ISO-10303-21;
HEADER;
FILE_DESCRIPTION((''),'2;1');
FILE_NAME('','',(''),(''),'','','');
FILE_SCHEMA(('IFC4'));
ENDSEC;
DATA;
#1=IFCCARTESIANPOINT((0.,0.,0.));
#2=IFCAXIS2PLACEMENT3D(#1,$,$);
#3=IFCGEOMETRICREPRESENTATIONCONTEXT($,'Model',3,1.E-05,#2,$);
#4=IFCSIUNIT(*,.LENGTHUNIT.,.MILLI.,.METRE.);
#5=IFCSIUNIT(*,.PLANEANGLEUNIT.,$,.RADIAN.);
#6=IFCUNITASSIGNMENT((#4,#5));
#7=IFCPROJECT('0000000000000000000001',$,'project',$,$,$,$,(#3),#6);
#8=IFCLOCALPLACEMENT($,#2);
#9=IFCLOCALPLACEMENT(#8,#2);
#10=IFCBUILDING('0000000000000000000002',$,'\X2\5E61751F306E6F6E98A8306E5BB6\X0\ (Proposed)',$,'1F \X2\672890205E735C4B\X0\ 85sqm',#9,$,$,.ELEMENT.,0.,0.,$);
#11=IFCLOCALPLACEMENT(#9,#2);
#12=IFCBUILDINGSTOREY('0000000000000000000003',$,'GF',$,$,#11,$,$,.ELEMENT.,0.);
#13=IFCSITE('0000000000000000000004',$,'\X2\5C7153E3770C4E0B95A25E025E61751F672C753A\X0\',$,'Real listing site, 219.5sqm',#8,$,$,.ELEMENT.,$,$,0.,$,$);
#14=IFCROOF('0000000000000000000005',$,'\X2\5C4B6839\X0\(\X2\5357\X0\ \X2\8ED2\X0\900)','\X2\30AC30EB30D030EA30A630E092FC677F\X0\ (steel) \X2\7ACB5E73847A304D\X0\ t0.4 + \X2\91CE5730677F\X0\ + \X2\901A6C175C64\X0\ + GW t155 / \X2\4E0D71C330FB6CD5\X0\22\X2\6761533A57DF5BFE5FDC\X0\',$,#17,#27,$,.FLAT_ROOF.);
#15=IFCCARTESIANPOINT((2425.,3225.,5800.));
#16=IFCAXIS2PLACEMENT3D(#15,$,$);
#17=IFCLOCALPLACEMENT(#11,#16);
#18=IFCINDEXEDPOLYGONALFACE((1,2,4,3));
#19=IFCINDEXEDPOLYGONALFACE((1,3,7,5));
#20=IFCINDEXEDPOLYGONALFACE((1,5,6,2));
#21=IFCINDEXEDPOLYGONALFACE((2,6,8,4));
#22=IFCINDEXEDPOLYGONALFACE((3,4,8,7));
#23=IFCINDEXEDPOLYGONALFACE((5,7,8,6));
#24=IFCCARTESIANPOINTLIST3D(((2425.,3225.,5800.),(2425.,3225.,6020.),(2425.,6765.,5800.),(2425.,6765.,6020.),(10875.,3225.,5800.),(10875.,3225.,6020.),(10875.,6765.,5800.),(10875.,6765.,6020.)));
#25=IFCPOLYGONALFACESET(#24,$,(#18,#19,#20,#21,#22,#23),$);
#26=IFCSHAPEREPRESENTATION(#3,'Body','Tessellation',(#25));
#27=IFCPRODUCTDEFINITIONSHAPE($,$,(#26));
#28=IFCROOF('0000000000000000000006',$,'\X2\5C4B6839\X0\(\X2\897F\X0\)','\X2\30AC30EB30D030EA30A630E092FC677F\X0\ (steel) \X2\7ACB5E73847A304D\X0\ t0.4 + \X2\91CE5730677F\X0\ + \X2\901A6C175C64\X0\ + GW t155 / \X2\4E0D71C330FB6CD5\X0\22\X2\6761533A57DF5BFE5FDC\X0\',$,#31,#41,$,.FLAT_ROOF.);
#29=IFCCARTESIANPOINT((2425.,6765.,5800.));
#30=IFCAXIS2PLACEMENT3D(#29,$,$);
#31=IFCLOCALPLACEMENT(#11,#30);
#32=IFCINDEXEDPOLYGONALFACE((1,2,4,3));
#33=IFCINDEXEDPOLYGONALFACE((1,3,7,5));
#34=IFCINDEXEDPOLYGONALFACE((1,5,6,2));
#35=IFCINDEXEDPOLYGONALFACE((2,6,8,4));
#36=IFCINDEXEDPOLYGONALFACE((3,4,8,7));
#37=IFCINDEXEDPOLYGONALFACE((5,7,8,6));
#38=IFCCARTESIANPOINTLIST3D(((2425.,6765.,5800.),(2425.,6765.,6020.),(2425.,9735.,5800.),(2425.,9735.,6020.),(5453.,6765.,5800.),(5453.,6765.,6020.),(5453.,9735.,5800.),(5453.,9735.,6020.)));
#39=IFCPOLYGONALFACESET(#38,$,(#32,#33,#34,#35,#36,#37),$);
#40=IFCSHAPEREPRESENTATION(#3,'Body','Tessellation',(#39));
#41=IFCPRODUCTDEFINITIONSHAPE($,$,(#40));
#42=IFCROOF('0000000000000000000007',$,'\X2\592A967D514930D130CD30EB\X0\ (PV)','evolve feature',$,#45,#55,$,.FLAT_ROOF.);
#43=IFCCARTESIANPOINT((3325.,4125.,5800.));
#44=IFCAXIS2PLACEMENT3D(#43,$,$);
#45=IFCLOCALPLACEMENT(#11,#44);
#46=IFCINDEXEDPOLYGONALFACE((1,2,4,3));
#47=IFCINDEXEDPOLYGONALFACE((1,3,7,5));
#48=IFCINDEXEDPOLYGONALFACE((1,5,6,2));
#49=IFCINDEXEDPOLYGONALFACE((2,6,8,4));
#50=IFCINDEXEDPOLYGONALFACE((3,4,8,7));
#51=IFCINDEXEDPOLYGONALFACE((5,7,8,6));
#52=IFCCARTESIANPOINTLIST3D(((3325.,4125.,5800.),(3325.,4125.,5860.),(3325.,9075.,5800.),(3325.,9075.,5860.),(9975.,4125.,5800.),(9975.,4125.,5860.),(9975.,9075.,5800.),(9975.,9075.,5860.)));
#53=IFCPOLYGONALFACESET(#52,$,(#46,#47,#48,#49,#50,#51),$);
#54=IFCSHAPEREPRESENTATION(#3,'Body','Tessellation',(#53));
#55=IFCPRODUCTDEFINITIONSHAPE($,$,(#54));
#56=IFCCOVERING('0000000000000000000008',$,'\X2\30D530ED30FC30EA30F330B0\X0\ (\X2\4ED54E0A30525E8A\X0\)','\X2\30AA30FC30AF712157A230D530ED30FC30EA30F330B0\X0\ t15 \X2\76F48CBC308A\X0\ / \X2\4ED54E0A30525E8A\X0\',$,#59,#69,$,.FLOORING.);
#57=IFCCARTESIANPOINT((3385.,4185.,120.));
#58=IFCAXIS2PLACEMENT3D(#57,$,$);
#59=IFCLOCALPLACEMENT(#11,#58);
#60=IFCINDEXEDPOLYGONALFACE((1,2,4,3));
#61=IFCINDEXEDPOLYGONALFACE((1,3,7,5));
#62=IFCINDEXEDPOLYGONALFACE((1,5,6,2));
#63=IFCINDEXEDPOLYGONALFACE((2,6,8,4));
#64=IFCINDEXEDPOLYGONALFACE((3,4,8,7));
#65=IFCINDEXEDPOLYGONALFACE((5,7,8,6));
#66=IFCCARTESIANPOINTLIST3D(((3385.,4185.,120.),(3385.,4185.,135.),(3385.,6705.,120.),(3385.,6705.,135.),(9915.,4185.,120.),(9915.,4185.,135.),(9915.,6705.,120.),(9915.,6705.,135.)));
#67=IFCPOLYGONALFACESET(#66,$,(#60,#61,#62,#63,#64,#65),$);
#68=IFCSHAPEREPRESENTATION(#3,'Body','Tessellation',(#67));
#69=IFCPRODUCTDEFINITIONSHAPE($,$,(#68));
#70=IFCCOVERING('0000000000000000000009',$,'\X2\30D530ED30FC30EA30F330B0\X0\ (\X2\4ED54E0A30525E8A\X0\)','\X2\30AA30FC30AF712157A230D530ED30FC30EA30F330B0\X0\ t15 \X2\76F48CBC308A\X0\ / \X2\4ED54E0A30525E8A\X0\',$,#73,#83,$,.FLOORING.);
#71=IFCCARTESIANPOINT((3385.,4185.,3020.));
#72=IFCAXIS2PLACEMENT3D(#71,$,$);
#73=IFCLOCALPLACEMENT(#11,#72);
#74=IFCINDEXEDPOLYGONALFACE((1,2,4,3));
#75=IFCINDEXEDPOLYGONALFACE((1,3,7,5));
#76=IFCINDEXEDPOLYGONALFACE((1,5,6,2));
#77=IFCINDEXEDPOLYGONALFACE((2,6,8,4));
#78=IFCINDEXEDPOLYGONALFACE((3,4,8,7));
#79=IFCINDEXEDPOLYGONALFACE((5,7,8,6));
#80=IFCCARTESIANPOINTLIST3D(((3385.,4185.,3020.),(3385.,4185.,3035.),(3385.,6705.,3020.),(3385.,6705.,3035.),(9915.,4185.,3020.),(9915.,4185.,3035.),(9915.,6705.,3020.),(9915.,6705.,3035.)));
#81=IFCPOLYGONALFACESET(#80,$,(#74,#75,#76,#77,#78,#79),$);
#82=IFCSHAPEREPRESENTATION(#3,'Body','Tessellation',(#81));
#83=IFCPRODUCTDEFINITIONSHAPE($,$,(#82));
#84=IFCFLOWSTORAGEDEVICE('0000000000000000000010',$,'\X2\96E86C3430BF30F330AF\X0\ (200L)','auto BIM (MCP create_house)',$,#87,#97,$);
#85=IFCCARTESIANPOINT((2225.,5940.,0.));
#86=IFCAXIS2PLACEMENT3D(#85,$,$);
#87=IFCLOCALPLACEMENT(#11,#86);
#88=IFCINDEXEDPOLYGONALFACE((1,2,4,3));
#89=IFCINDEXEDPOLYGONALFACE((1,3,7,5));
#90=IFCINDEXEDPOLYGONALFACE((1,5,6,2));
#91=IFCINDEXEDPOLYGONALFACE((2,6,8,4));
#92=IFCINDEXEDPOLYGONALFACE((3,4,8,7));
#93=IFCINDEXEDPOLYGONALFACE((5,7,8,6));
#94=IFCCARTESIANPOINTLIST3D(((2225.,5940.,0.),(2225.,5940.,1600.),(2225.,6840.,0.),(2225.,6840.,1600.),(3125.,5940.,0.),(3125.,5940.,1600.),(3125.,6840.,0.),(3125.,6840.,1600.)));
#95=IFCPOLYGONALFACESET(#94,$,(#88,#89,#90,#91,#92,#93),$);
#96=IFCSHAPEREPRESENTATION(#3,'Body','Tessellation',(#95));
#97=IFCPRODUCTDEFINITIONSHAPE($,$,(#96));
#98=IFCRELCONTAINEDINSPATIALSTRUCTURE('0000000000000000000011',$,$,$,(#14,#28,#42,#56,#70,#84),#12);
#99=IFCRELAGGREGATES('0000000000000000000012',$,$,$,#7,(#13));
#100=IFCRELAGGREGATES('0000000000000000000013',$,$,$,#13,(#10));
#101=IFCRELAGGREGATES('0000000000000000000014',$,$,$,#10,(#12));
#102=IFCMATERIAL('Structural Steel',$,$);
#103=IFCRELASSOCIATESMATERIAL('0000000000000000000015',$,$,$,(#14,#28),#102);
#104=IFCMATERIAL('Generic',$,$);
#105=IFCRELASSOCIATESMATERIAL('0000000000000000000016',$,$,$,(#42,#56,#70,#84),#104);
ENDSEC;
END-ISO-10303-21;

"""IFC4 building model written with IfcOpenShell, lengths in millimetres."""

from ifc_helpers import new_model, si_unit, frame, frame_2d, origin, place, context, project, spatial, rectangle, extrude, material, element, save


model = new_model("IFC4")

# Units and contexts
model_context = context("Model", 3, precision=1e-05, world=origin())
ifc_project = project(units=[si_unit("LENGTHUNIT", "METRE", prefix="MILLI"), si_unit("PLANEANGLEUNIT", "RADIAN")], contexts=[model_context])

# Site, building, storey
site_placement = place(None, origin())
site = spatial("IfcSite", under=ifc_project, at=site_placement, Name="山口県下関市幡生本町", ObjectType="Real listing site, 219.5sqm", CompositionType="ELEMENT", RefElevation=0.0)
building_placement = place(site_placement, origin())
building = spatial("IfcBuilding", under=site, at=building_placement, Name="幡生の潮風の家 (Proposed)", ObjectType="1F 木造平屋 85sqm", CompositionType="ELEMENT", ElevationOfRefHeight=0.0, ElevationOfTerrain=0.0)
storey_placement = place(building_placement, origin())
storey = spatial("IfcBuildingStorey", under=building, at=storey_placement, Name="GF", CompositionType="ELEMENT", Elevation=0.0)

# Shared definitions
ifc_material_1 = material(Name="Generic")

# Roofs
ifc_material_2 = material(Name="Structural Steel")
roof_1_placement = place(storey_placement, frame((2425.0, 3225.0, 5800.0)))
element("IfcRoof", 1, at=roof_1_placement, inside=storey, material=ifc_material_2, Name="屋根(南 軒900)", Description="ガルバリウム鋼板 (steel) 立平葺き t0.4 + 野地板 + 通気層 + GW t155 / 不燃・法22条区域対応", PredefinedType="FLAT_ROOF", context=model_context, shape_type="SweptSolid", body=[
    extrude(rectangle(XDim=8450.0, YDim=3540.0, at=frame_2d((4225.0, 1770.0))), frame((2425.0, 3225.0, 5800.0)), (0.0, 0.0, 1.0), 220.0),
])
roof_2_placement = place(storey_placement, frame((2425.0, 6765.0, 5800.0)))
element("IfcRoof", 2, at=roof_2_placement, inside=storey, material=ifc_material_2, Name="屋根(西)", Description="ガルバリウム鋼板 (steel) 立平葺き t0.4 + 野地板 + 通気層 + GW t155 / 不燃・法22条区域対応", PredefinedType="FLAT_ROOF", context=model_context, shape_type="SweptSolid", body=[
    extrude(rectangle(XDim=3028.0, YDim=2970.0, at=frame_2d((1514.0, 1485.0))), frame((2425.0, 6765.0, 5800.0)), (0.0, 0.0, 1.0), 220.0),
])
roof_3_placement = place(storey_placement, frame((3325.0, 4125.0, 5800.0)))
element("IfcRoof", 3, at=roof_3_placement, inside=storey, material=ifc_material_1, Name="太陽光パネル (PV)", Description="evolve feature", PredefinedType="FLAT_ROOF", context=model_context, shape_type="SweptSolid", body=[
    extrude(rectangle(XDim=6650.0, YDim=4950.0, at=frame_2d((3325.0, 2475.0))), frame((3325.0, 4125.0, 5800.0)), (0.0, 0.0, 1.0), 60.0),
])

# Coverings
covering_1_placement = place(storey_placement, frame((3385.0, 4185.0, 120.0)))
element("IfcCovering", 4, at=covering_1_placement, inside=storey, material=ifc_material_1, Name="フローリング (仕上げ床)", Description="オーク無垢フローリング t15 直貼り / 仕上げ床", PredefinedType="FLOORING", context=model_context, shape_type="SweptSolid", body=[
    extrude(rectangle(XDim=6530.0, YDim=2520.0, at=frame_2d((3265.0, 1260.0))), frame((3385.0, 4185.0, 120.0)), (0.0, 0.0, 1.0), 15.0),
])
covering_2_placement = place(storey_placement, frame((3385.0, 4185.0, 3020.0)))
element("IfcCovering", 5, at=covering_2_placement, inside=storey, material=ifc_material_1, Name="フローリング (仕上げ床)", Description="オーク無垢フローリング t15 直貼り / 仕上げ床", PredefinedType="FLOORING", context=model_context, shape_type="SweptSolid", body=[
    extrude(rectangle(XDim=6530.0, YDim=2520.0, at=frame_2d((3265.0, 1260.0))), frame((3385.0, 4185.0, 3020.0)), (0.0, 0.0, 1.0), 15.0),
])

# Flow storage device
flow_storage_device_placement = place(storey_placement, frame((2225.0, 5940.0, 0.0)))
element("IfcFlowStorageDevice", 6, at=flow_storage_device_placement, inside=storey, material=ifc_material_1, Name="雨水タンク (200L)", Description="auto BIM (MCP create_house)", context=model_context, shape_type="SweptSolid", body=[
    extrude(rectangle(XDim=900.0, YDim=900.0, at=frame_2d((450.0, 450.0))), frame((2225.0, 5940.0, 0.0)), (0.0, 0.0, 1.0), 1600.0),
])

save(model, "model.ifc")
